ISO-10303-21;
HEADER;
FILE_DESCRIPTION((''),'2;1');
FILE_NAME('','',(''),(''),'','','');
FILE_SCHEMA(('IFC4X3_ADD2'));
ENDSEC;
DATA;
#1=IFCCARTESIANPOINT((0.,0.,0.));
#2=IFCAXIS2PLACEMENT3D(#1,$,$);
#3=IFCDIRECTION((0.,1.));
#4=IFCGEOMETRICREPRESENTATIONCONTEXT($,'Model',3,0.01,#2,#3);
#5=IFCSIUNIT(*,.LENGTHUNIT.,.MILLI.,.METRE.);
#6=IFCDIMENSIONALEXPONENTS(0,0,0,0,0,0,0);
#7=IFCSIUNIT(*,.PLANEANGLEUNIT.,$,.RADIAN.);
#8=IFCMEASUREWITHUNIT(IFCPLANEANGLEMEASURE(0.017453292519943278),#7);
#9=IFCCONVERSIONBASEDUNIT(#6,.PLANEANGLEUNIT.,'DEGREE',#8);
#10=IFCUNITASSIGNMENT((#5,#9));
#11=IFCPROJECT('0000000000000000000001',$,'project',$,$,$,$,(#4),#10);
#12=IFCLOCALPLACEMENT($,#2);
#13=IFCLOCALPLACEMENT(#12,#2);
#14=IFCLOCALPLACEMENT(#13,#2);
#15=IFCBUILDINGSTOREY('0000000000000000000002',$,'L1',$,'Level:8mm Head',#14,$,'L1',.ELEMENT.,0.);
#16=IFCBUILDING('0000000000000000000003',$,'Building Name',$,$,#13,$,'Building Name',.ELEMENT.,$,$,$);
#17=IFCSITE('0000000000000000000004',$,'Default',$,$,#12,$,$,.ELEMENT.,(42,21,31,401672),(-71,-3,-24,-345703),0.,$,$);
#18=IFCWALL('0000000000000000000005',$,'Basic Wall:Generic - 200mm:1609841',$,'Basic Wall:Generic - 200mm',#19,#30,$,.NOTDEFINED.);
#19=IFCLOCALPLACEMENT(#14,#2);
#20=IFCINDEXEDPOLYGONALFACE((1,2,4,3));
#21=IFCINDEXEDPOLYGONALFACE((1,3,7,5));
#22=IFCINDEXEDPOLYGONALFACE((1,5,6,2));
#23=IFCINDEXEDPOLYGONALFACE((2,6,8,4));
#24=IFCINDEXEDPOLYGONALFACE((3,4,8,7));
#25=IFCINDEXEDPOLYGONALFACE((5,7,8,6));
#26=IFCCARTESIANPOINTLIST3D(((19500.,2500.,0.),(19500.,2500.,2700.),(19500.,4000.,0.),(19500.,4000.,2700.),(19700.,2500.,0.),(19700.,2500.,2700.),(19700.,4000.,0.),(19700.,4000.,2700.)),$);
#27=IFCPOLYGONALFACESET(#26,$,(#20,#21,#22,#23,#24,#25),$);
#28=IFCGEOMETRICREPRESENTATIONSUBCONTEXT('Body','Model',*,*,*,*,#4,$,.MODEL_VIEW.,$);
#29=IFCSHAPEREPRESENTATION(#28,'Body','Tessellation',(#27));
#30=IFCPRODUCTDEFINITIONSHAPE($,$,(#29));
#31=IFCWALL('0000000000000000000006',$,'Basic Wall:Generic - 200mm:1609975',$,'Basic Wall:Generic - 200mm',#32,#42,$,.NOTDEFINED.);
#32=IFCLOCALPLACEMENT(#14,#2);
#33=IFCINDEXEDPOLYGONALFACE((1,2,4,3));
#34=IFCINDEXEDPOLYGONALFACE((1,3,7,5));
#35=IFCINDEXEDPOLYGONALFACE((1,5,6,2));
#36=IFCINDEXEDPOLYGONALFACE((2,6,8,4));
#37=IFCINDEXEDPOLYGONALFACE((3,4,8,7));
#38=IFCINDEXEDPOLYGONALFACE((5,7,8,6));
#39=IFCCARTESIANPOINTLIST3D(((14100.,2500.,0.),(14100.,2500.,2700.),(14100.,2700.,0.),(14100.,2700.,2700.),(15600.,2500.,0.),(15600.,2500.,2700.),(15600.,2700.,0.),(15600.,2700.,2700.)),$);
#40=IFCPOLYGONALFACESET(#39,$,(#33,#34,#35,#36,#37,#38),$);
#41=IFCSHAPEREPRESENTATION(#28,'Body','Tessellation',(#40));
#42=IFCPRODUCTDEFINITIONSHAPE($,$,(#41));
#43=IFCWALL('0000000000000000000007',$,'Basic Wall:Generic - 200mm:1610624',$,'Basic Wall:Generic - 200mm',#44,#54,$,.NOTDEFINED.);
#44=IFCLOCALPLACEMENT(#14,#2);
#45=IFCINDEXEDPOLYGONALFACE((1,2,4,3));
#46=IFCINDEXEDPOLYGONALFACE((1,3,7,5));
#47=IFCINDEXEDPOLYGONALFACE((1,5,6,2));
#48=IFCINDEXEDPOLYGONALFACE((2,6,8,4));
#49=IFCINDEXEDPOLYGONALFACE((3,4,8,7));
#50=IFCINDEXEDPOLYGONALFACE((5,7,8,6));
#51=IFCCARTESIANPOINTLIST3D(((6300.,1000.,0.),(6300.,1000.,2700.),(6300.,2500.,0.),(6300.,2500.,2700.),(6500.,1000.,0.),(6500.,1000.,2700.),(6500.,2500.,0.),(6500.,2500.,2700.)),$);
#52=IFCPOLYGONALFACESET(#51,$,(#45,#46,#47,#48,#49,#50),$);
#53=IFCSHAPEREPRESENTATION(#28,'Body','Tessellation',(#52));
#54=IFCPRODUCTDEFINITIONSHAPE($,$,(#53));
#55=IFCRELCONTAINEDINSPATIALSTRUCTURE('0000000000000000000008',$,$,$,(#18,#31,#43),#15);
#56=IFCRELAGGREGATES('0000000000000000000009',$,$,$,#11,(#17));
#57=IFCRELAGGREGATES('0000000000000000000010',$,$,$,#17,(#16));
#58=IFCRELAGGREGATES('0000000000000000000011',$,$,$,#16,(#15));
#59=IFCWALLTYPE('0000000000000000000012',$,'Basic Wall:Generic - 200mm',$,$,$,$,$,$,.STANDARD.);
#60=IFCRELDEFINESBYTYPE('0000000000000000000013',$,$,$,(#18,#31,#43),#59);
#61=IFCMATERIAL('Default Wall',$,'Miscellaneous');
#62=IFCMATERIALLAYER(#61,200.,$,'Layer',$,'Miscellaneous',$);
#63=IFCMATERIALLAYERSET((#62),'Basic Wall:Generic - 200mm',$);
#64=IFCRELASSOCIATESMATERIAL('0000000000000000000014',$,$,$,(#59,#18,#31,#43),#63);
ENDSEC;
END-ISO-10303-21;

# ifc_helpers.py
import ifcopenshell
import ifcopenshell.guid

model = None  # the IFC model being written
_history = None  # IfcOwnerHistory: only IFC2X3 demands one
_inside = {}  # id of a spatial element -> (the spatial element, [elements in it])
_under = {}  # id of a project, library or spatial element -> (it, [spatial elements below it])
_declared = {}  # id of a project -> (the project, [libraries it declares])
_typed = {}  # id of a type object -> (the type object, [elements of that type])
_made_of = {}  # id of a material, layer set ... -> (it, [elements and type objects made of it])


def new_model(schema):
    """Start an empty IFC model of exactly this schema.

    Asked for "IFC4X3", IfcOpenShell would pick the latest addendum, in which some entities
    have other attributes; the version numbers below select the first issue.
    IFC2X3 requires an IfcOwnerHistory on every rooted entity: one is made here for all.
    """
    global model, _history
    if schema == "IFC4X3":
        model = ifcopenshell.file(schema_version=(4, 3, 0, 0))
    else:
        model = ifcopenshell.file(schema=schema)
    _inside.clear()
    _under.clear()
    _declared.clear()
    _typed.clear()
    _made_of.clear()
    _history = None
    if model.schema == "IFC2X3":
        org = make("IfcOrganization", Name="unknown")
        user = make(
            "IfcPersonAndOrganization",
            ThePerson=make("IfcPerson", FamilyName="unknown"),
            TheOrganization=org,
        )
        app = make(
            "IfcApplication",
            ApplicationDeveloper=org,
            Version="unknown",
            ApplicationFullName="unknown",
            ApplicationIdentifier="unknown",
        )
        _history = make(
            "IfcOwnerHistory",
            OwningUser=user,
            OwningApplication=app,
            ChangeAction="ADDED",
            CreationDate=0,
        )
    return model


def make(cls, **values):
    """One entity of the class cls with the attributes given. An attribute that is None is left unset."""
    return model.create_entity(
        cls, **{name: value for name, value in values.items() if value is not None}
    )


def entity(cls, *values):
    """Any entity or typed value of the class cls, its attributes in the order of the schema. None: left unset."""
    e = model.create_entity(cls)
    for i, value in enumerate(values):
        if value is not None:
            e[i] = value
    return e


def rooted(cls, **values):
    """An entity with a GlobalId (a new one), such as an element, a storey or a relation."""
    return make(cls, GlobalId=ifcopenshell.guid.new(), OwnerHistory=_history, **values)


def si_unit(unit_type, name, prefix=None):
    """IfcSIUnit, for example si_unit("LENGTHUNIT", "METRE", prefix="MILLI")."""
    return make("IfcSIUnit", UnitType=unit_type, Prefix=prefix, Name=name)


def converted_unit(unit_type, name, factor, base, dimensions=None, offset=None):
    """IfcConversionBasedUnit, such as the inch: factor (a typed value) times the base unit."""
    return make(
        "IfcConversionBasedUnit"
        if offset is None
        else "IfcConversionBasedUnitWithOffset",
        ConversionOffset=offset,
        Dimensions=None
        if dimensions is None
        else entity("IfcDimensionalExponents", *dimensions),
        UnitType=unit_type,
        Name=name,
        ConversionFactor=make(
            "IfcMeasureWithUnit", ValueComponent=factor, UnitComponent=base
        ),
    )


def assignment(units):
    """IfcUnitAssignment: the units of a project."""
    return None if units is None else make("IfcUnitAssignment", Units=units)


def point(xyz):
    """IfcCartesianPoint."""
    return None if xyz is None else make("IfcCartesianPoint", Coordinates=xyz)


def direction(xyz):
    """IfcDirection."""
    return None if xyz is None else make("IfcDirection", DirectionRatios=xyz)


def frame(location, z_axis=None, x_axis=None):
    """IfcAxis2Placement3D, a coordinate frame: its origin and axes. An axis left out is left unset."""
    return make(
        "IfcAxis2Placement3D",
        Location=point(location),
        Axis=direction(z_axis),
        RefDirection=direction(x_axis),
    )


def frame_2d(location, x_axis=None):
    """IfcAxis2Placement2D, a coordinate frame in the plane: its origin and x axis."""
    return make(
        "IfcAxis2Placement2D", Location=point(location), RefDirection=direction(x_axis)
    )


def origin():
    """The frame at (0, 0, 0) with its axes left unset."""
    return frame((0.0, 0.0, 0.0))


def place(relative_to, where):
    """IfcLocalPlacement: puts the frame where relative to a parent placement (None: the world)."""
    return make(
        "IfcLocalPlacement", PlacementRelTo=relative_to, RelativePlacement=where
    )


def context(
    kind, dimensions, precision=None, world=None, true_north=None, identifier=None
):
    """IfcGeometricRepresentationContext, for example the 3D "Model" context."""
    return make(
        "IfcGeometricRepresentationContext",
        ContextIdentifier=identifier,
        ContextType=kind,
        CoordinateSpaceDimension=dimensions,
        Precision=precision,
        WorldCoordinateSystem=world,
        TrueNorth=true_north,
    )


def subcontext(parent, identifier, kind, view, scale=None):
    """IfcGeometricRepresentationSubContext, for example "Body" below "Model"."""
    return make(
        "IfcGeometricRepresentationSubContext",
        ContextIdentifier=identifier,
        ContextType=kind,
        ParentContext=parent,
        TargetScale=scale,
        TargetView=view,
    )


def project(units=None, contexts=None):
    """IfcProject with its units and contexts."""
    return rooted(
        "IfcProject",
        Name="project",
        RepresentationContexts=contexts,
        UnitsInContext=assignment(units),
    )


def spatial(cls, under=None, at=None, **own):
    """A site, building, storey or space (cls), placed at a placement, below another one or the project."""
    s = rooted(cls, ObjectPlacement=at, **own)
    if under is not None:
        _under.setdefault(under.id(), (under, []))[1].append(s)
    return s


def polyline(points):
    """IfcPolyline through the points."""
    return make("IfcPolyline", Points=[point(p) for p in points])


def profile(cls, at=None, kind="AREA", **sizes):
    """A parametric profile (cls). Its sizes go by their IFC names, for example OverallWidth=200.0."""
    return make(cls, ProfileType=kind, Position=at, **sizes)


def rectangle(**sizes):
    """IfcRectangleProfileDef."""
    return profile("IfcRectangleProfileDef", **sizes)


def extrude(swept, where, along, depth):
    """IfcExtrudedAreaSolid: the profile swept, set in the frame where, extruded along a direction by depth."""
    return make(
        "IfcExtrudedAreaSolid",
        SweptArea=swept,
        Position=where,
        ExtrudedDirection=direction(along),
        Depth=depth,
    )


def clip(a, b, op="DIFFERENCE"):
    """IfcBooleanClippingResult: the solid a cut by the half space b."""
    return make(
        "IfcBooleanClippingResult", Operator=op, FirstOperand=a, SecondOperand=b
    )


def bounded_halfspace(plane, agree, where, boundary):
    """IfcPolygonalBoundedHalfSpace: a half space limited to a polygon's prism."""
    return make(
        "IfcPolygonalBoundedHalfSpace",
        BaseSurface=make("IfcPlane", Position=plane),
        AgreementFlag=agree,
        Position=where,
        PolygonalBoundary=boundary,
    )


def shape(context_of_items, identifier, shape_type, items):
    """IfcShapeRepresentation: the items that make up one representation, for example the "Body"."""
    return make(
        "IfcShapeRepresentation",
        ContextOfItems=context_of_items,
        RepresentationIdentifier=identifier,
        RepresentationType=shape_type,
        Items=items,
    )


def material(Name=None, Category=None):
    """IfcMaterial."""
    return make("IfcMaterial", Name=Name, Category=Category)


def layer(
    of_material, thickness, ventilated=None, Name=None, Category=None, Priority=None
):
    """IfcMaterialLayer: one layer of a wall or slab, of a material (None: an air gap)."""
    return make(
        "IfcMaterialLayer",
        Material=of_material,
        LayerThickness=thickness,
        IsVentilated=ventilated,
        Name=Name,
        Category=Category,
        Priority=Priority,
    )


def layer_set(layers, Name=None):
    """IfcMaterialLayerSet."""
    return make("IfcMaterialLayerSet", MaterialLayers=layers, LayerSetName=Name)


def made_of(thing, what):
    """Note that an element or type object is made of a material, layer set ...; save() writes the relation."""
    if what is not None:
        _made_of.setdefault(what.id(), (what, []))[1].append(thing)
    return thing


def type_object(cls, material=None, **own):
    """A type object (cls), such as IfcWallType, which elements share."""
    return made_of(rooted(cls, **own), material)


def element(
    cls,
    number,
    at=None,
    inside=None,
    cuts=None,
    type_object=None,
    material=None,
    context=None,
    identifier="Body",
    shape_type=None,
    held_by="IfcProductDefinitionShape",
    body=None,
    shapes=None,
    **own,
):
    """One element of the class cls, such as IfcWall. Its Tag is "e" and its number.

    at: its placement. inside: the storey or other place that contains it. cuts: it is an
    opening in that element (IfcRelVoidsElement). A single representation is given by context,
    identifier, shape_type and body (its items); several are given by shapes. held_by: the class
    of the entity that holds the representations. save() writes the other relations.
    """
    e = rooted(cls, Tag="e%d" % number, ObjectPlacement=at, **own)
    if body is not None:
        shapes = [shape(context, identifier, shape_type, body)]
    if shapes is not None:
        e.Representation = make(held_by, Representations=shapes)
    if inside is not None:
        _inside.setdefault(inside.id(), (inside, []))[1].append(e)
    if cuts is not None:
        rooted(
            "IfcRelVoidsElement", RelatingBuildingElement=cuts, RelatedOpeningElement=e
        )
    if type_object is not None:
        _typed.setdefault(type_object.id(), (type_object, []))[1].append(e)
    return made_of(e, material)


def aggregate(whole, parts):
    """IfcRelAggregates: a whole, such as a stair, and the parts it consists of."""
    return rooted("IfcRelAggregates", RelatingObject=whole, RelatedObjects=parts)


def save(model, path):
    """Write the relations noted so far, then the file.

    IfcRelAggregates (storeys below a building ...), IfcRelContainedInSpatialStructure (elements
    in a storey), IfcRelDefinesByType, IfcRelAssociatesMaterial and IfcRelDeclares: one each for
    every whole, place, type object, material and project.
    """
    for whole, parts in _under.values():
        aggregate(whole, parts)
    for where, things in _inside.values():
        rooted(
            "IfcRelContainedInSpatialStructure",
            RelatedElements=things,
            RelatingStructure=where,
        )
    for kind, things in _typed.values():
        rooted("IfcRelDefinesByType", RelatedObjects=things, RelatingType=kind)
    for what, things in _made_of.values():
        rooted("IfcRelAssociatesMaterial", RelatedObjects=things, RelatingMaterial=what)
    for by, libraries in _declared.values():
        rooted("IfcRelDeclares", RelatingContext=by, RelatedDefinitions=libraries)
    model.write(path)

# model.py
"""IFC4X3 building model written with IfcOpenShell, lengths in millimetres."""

from ifc_helpers import new_model, entity, si_unit, converted_unit, direction, frame, frame_2d, origin, place, context, subcontext, project, spatial, polyline, rectangle, extrude, clip, bounded_halfspace, material, layer, layer_set, type_object, element, save


model = new_model("IFC4X3")

# Units and contexts
model_context = context("Model", 3, precision=0.01, world=origin(), true_north=direction((0.0, 1.0)))
body_context = subcontext(model_context, "Body", "Model", "MODEL_VIEW")
ifc_project = project(units=[si_unit("LENGTHUNIT", "METRE", prefix="MILLI"), converted_unit("PLANEANGLEUNIT", "DEGREE", entity("IfcPlaneAngleMeasure", 0.017453292519943278), si_unit("PLANEANGLEUNIT", "RADIAN"), dimensions=[0, 0, 0, 0, 0, 0, 0])], contexts=[model_context])

# Site, building, storey
site_placement = place(None, origin())
site = spatial("IfcSite", under=ifc_project, at=site_placement, Name="Default", CompositionType="ELEMENT", RefLatitude=(42, 21, 31, 401672), RefLongitude=(-71, -3, -24, -345703), RefElevation=0.0)
building_placement = place(site_placement, origin())
building = spatial("IfcBuilding", under=site, at=building_placement, Name="Building Name", LongName="Building Name", CompositionType="ELEMENT")
storey_placement = place(building_placement, origin())
storey = spatial("IfcBuildingStorey", under=building, at=storey_placement, Name="L1", ObjectType="Level:8mm Head", LongName="L1", CompositionType="ELEMENT", Elevation=0.0)

# Walls
ifc_material = material(Name="Default Wall", Category="Miscellaneous")
ifc_layer = layer(ifc_material, 200.0, Name="Layer", Category="Miscellaneous")
ifc_layer_set = layer_set([ifc_layer], Name="Basic Wall:Generic - 200mm")
wall_type = type_object("IfcWallType", Name="Basic Wall:Generic - 200mm", PredefinedType="STANDARD", material=ifc_layer_set)
wall_1_placement = place(storey_placement, frame((19600.0, 2500.0, 0.0), z_axis=(0.0, 0.0, 1.0), x_axis=(0.0, 1.0, 0.0)))
element("IfcWall", 1, at=wall_1_placement, inside=storey, type_object=wall_type, material=ifc_layer_set, Name="Basic Wall:Generic - 200mm:1609841", ObjectType="Basic Wall:Generic - 200mm", PredefinedType="NOTDEFINED", context=body_context, shape_type="Clipping", body=[
    clip(extrude(rectangle(XDim=1500.0, YDim=200.0, at=frame_2d((750.0, 0.0), x_axis=(-1.0, 0.0))), origin(), (0.0, 0.0, 1.0), 2700.0), bounded_halfspace(frame((0.0, -100.0, 2700.0), z_axis=(0.0, 0.0, -1.0), x_axis=(0.0, 1.0, 0.0)), True, frame((0.0, -100.0, 2700.0)), polyline([(0.0, 0.0), (1500.0, 0.0), (1500.0, 200.0), (0.0, 200.0), (0.0, 0.0)]))),
])
wall_2_placement = place(storey_placement, frame((14100.0, 2600.0, 0.0)))
element("IfcWall", 2, at=wall_2_placement, inside=storey, type_object=wall_type, material=ifc_layer_set, Name="Basic Wall:Generic - 200mm:1609975", ObjectType="Basic Wall:Generic - 200mm", PredefinedType="NOTDEFINED", context=body_context, shape_type="Clipping", body=[
    clip(extrude(rectangle(XDim=1500.0, YDim=200.0, at=frame_2d((750.0, 0.0), x_axis=(-1.0, 0.0))), origin(), (0.0, 0.0, 1.0), 2700.0), bounded_halfspace(frame((0.0, -100.0, 2700.0), z_axis=(0.0, 0.0, -1.0), x_axis=(-1.0, 0.0, 0.0)), True, frame((0.0, -100.0, 2700.0)), polyline([(0.0, 0.0), (1500.0, 0.0), (1500.0, 200.0), (0.0, 200.0), (0.0, 0.0)]))),
])
wall_3_placement = place(storey_placement, frame((6400.0, 2500.0, 0.0), z_axis=(0.0, 0.0, 1.0), x_axis=(0.0, -1.0, 0.0)))
element("IfcWall", 3, at=wall_3_placement, inside=storey, type_object=wall_type, material=ifc_layer_set, Name="Basic Wall:Generic - 200mm:1610624", ObjectType="Basic Wall:Generic - 200mm", PredefinedType="NOTDEFINED", context=body_context, shape_type="Clipping", body=[
    clip(extrude(rectangle(XDim=1500.0, YDim=200.0, at=frame_2d((750.0, 0.0), x_axis=(-1.0, 0.0))), origin(), (0.0, 0.0, 1.0), 2700.0), bounded_halfspace(frame((0.0, -100.0, 2700.0), z_axis=(0.0, 0.0, -1.0), x_axis=(0.0, -1.0, 0.0)), True, frame((0.0, -100.0, 2700.0)), polyline([(0.0, 0.0), (1500.0, 0.0), (1500.0, 200.0), (0.0, 200.0), (0.0, 0.0)]))),
])

save(model, "model.ifc")
